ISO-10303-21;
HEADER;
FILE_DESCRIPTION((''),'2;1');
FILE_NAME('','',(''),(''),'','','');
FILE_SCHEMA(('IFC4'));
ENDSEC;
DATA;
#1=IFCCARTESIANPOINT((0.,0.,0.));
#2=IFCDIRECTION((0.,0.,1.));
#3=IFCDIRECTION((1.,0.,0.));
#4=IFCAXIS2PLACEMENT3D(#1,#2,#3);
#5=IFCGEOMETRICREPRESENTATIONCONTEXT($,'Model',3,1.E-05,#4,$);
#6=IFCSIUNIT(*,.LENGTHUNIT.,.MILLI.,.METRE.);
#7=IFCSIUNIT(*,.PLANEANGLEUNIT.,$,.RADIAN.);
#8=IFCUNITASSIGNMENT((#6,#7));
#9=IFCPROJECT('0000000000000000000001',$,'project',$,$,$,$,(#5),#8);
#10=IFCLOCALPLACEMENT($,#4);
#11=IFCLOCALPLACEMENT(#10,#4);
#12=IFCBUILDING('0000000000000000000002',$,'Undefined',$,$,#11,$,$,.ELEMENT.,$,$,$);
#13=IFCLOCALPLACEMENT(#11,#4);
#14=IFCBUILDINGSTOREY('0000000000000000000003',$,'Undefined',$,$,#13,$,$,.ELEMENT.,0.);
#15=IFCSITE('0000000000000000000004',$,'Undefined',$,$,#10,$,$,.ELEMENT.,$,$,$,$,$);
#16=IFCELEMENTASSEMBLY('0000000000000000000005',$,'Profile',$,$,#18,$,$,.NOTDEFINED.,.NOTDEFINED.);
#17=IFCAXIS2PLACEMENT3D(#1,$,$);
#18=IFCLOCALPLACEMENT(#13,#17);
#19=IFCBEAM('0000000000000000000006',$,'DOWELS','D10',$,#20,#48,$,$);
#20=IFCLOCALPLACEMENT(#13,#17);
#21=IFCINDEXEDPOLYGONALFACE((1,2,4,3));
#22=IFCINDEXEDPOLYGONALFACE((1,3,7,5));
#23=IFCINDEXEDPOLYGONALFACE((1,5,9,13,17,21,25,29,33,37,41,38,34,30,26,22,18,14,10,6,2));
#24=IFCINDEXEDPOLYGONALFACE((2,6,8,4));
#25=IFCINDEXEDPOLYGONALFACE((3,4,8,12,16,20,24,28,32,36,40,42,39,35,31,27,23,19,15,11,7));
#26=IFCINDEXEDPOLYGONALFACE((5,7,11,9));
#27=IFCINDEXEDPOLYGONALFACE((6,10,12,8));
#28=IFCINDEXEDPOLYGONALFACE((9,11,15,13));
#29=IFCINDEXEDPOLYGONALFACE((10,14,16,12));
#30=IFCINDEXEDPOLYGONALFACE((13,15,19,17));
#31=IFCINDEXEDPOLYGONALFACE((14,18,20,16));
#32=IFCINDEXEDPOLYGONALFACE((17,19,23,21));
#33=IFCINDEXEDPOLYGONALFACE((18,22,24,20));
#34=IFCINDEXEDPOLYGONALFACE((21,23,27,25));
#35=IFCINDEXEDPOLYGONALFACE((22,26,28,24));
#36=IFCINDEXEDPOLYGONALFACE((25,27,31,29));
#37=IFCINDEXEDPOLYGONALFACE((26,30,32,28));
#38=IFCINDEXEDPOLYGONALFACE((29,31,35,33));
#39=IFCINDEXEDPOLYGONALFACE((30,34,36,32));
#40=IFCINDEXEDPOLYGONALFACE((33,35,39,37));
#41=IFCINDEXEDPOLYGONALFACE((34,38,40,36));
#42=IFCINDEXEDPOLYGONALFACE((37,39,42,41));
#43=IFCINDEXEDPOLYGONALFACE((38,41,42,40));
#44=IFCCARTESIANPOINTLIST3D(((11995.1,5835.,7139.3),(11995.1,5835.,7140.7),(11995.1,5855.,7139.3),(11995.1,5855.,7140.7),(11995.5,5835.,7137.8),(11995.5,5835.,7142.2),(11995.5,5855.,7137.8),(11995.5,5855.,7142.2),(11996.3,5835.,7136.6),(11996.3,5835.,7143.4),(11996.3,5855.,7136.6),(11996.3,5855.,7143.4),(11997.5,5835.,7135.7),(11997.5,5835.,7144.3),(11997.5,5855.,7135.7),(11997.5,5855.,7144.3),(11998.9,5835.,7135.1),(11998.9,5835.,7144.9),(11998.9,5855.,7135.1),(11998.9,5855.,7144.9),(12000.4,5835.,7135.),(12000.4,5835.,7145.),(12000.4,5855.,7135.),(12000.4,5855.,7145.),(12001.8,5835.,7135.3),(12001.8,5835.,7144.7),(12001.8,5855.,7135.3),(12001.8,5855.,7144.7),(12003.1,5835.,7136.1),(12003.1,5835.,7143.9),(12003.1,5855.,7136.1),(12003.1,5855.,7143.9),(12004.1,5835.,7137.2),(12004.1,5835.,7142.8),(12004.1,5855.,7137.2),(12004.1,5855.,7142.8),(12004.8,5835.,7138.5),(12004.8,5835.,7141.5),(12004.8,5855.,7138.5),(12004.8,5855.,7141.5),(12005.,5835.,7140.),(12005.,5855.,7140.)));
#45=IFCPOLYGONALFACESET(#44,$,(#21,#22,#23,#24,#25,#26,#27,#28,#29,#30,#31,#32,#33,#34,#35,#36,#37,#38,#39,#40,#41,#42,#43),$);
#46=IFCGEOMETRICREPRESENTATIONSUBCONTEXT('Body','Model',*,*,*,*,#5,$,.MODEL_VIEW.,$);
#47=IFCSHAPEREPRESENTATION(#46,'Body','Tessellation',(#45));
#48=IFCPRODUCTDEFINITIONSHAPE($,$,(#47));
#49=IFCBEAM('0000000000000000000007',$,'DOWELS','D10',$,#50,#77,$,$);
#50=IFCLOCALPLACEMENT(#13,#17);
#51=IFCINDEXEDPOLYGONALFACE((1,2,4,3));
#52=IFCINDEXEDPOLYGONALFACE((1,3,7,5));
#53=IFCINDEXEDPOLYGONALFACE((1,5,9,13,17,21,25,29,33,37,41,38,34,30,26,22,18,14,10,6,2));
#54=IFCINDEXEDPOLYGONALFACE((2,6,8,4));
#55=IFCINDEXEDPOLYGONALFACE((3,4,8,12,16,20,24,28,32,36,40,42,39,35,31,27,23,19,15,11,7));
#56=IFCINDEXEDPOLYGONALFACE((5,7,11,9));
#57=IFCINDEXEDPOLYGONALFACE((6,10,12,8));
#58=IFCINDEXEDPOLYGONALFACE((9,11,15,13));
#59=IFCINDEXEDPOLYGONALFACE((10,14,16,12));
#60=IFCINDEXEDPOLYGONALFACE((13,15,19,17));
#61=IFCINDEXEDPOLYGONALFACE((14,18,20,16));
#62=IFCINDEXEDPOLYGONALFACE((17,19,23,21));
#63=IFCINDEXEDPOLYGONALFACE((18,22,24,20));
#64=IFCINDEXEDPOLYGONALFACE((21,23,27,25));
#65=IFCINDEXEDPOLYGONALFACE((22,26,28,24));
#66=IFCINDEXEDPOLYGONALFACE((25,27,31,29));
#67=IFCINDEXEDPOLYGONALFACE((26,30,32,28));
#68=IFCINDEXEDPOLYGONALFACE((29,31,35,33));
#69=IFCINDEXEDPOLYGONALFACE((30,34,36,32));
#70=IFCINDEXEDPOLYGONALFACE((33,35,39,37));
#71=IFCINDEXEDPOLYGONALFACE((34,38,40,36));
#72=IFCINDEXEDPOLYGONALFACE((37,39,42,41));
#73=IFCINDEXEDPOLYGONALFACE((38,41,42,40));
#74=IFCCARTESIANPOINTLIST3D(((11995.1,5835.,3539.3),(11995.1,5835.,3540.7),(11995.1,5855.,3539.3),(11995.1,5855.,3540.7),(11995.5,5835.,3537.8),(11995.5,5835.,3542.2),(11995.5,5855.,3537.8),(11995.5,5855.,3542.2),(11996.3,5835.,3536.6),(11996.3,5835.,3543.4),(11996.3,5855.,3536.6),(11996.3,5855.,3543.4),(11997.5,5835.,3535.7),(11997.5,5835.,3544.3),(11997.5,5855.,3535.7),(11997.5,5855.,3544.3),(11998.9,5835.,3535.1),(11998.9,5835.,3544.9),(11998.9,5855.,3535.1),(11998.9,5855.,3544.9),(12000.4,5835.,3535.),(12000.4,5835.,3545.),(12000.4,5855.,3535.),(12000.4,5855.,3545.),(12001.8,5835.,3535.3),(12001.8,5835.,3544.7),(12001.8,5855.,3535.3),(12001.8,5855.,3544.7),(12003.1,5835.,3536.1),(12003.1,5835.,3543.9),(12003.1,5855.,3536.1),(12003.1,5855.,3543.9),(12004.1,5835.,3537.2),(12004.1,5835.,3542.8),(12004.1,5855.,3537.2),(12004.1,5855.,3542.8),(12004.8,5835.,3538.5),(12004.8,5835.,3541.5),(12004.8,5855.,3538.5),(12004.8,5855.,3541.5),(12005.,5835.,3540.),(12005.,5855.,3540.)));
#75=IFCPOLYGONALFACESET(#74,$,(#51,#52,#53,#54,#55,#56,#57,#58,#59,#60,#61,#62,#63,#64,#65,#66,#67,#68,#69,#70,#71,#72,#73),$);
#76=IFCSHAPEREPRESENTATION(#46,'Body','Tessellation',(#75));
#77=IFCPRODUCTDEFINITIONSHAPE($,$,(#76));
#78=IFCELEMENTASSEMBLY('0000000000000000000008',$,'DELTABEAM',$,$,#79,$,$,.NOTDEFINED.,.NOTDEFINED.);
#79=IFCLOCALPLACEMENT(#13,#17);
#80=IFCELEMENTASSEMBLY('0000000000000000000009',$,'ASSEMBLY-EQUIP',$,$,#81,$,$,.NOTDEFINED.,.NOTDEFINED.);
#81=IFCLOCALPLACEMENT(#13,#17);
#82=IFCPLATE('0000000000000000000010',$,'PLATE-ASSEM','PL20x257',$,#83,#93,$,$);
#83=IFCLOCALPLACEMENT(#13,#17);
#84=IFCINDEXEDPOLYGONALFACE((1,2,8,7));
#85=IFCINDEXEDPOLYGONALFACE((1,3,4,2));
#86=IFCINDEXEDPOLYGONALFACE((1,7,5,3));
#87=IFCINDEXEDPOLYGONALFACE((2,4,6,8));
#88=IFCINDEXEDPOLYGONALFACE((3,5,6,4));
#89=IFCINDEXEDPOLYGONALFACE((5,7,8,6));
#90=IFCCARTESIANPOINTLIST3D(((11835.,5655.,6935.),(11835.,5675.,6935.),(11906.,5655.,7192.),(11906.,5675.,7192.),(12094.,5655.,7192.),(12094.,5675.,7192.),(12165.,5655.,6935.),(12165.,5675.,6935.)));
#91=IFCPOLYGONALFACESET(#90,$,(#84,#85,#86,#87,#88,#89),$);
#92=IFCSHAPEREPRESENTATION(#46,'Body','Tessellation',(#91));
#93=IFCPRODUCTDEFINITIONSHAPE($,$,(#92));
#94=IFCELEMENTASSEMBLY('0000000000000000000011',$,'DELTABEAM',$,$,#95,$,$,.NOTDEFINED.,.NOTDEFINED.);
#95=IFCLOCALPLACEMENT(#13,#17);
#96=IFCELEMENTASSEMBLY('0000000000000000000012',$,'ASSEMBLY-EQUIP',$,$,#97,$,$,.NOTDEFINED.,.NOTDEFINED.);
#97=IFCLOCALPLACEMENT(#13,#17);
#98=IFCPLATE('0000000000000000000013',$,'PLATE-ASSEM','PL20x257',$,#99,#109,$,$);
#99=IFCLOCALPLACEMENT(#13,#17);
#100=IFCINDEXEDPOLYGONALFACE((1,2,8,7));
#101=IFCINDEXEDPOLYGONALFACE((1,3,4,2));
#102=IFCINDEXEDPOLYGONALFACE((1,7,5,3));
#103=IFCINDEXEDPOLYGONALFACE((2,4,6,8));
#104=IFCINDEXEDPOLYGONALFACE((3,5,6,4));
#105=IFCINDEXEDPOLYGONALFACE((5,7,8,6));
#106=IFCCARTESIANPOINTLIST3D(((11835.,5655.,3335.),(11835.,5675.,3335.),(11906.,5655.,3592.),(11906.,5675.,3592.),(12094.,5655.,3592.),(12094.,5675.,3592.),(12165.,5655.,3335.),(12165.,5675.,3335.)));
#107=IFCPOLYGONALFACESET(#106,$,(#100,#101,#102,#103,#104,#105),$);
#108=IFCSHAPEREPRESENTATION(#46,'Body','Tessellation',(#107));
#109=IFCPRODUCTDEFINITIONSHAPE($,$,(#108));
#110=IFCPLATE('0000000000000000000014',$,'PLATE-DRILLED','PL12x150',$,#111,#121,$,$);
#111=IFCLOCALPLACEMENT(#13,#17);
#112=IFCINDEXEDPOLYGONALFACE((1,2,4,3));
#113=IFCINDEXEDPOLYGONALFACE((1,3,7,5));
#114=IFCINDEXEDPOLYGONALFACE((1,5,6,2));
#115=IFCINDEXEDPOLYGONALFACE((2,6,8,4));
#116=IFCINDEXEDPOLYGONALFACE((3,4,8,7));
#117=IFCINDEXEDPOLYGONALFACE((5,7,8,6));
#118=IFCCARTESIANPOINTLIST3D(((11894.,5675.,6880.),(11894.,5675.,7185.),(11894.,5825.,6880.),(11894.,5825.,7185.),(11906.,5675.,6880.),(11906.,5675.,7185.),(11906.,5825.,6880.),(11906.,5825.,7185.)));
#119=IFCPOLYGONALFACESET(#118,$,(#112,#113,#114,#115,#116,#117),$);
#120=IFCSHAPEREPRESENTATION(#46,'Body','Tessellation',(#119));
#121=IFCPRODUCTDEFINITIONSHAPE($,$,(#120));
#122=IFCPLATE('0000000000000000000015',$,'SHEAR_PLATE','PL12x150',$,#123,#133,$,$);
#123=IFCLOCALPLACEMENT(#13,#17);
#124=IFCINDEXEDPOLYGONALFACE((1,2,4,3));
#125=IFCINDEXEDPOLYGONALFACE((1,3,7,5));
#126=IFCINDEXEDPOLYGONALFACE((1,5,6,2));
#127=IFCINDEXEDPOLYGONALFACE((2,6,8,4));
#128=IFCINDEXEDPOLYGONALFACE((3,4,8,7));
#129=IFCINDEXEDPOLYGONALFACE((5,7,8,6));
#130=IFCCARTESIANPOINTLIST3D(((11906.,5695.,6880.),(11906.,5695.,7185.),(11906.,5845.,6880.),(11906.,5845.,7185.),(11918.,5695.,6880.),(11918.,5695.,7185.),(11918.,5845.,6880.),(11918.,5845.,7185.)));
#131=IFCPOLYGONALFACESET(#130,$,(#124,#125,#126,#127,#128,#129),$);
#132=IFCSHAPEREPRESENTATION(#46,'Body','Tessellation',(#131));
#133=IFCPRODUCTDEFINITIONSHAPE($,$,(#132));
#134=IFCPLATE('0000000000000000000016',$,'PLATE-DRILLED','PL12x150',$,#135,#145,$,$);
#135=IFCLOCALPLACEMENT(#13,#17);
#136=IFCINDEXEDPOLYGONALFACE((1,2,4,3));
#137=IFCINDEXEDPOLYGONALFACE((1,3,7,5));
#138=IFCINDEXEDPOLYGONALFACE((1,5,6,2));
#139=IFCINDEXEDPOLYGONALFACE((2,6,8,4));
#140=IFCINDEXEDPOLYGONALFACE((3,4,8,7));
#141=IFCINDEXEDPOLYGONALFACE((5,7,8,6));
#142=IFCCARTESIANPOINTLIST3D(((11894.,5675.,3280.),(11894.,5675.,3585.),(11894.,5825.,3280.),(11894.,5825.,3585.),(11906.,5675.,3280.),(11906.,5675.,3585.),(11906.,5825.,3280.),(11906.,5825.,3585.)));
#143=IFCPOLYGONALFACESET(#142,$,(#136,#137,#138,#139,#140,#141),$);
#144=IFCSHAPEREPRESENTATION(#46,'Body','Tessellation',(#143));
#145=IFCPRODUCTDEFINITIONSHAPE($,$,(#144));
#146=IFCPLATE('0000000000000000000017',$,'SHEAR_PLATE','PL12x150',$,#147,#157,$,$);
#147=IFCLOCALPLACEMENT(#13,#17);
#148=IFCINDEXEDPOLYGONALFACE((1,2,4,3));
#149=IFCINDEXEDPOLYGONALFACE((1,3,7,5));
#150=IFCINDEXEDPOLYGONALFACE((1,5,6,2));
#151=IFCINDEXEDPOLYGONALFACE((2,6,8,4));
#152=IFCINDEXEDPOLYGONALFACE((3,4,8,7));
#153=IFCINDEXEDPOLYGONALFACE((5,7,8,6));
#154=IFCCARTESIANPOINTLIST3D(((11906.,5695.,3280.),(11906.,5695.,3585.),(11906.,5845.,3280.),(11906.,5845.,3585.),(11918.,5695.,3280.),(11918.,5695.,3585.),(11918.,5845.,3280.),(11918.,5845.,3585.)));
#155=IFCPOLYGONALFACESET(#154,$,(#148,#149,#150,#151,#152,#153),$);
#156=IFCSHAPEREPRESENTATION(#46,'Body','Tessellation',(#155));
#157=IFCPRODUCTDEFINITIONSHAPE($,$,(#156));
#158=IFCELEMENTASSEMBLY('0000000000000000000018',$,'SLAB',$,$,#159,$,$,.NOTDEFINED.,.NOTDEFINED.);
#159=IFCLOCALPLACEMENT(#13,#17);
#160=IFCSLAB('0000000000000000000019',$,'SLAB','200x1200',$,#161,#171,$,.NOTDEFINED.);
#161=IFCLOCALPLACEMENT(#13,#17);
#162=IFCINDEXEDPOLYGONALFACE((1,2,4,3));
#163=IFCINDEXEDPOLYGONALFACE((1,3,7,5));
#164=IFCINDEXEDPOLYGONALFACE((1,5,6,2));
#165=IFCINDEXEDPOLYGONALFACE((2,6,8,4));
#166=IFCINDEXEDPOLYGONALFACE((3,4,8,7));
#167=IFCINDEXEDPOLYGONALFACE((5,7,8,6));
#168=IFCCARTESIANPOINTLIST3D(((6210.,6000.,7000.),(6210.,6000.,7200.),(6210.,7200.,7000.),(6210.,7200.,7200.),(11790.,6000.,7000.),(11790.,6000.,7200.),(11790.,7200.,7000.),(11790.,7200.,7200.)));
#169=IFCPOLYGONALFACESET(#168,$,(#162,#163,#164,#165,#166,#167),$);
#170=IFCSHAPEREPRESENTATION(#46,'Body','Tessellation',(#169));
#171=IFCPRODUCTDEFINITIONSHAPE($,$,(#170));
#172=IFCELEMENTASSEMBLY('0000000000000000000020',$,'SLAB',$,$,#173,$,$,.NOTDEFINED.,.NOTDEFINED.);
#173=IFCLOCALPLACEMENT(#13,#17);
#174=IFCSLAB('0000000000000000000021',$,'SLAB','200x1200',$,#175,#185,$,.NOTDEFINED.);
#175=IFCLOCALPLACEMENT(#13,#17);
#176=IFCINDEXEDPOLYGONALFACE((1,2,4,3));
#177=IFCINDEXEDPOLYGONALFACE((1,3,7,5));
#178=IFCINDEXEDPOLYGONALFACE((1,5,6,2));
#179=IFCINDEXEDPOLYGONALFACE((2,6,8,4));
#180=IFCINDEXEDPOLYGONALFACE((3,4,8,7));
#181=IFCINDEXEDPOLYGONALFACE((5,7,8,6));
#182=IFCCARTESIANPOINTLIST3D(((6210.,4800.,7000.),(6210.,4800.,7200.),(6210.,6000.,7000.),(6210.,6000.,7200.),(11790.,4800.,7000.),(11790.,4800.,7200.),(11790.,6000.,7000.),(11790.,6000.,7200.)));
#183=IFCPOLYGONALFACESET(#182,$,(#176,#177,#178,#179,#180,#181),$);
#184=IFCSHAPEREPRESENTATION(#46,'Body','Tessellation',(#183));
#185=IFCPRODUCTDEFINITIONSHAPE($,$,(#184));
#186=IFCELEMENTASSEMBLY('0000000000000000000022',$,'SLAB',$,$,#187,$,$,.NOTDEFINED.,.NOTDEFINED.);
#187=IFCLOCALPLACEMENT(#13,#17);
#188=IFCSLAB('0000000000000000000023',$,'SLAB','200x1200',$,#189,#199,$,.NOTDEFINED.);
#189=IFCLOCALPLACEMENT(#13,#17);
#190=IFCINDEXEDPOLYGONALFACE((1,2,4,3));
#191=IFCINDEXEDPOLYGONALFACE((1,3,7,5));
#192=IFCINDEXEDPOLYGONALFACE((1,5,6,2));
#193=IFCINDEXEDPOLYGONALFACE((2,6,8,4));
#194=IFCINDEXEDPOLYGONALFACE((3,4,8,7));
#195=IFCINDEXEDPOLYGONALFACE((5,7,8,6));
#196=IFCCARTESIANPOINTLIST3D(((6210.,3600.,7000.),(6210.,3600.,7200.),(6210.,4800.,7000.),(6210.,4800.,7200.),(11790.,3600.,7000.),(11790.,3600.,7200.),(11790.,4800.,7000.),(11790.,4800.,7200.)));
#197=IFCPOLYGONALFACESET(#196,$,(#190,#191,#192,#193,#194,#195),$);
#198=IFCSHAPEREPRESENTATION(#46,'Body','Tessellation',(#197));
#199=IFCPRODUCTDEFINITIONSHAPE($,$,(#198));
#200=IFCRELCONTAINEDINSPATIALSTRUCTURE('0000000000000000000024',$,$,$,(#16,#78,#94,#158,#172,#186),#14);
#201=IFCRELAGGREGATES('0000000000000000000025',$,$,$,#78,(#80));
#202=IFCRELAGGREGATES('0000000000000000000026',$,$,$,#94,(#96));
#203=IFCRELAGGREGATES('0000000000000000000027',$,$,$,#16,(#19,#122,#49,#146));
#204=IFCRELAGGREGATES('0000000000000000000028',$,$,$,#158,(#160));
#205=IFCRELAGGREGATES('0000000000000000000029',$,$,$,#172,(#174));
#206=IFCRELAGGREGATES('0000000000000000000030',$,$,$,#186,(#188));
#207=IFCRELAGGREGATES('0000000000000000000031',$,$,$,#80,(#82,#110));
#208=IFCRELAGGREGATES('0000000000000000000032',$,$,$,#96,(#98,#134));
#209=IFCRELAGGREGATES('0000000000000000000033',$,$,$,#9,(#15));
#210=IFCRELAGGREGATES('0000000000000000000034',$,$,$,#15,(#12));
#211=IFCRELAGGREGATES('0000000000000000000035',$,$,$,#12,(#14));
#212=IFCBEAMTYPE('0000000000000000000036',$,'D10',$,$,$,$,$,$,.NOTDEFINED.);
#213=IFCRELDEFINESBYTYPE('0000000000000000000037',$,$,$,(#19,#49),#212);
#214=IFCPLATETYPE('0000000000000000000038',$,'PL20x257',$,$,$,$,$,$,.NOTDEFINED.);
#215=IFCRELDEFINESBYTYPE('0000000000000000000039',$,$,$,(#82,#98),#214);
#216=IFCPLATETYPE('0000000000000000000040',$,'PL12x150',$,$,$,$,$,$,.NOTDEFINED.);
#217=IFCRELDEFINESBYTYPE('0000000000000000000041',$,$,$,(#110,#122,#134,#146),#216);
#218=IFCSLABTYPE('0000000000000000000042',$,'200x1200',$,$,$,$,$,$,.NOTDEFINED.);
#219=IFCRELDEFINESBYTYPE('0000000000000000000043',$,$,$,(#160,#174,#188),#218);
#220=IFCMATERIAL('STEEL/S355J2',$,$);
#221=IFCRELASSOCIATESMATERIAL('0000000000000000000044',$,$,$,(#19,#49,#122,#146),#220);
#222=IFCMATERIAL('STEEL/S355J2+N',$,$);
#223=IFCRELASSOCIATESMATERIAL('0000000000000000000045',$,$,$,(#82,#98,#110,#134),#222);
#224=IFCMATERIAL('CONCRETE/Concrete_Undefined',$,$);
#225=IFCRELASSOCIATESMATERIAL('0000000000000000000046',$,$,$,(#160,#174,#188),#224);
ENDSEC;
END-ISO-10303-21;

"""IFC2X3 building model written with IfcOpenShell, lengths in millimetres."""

from ifc_helpers import new_model, si_unit, frame, origin_with_axes, origin_2d_with_axis, place, context, subcontext, project, spatial, polyline, circle, outline, extrude, material, type_object, element, aggregate, save


model = new_model("IFC2X3")

# Units and contexts
model_context = context("Model", 3, precision=1e-05, world=origin_with_axes())
body_context = subcontext(model_context, "Body", "Model", "MODEL_VIEW")
ifc_project = project(units=[si_unit("LENGTHUNIT", "METRE", prefix="MILLI"), si_unit("PLANEANGLEUNIT", "RADIAN")], contexts=[model_context])

# Site, building, storey
site_placement = place(None, origin_with_axes())
site = spatial("IfcSite", under=ifc_project, at=site_placement, Name="Undefined", CompositionType="ELEMENT")
building_placement = place(site_placement, origin_with_axes())
building = spatial("IfcBuilding", under=site, at=building_placement, Name="Undefined", CompositionType="ELEMENT")
storey_placement = place(building_placement, origin_with_axes())
storey = spatial("IfcBuildingStorey", under=building, at=storey_placement, Name="Undefined", CompositionType="ELEMENT", Elevation=0.0)

# Element assembly, beams
assembly_1_placement = place(storey_placement, origin_with_axes())
assembly_1 = element("IfcElementAssembly", 1, at=assembly_1_placement, inside=storey, Name="Profile", AssemblyPlace="NOTDEFINED", PredefinedType="NOTDEFINED")
ifc_material_1 = material(Name="STEEL/S355J2")
beam_type_1 = type_object("IfcBeamType", Name="D10", PredefinedType="NOTDEFINED")
beam_1_placement = place(assembly_1_placement, frame((12000.0, 5835.0, 7140.0), z_axis=(0.0, 0.0, 1.0), x_axis=(0.0, 1.0, 0.0)))
beam_1 = element("IfcBeam", 2, at=beam_1_placement, type_object=beam_type_1, material=ifc_material_1, Name="DOWELS", Description="D10", context=body_context, shape_type="SweptSolid", body=[
    extrude(circle(Radius=5.0, at=origin_2d_with_axis()), frame((20.0, 0.0, 0.0), z_axis=(-1.0, 0.0, 0.0), x_axis=(0.0, -1.0, 0.0)), (0.0, 0.0, 1.0), 20.0),
])
beam_2_placement = place(assembly_1_placement, frame((12000.0, 5835.0, 3540.0), z_axis=(0.0, 0.0, 1.0), x_axis=(0.0, 1.0, 0.0)))
beam_2 = element("IfcBeam", 3, at=beam_2_placement, type_object=beam_type_1, material=ifc_material_1, Name="DOWELS", Description="D10", context=body_context, shape_type="SweptSolid", body=[
    extrude(circle(Radius=5.0, at=origin_2d_with_axis()), frame((20.0, 0.0, 0.0), z_axis=(-1.0, 0.0, 0.0), x_axis=(0.0, -1.0, 0.0)), (0.0, 0.0, 1.0), 20.0),
])

# Element assemblies, plates
assembly_2_placement = place(storey_placement, origin_with_axes())
assembly_2 = element("IfcElementAssembly", 4, at=assembly_2_placement, inside=storey, Name="DELTABEAM", AssemblyPlace="NOTDEFINED", PredefinedType="NOTDEFINED")
assembly_3_placement = place(assembly_2_placement, origin_with_axes())
assembly_3 = element("IfcElementAssembly", 5, at=assembly_3_placement, Name="ASSEMBLY-EQUIP", AssemblyPlace="NOTDEFINED", PredefinedType="NOTDEFINED")
aggregate(assembly_2, [assembly_3])
ifc_material_2 = material(Name="STEEL/S355J2+N")
plate_type_1 = type_object("IfcPlateType", Name="PL20x257", PredefinedType="NOTDEFINED")
plate_1_placement = place(assembly_3_placement, frame((11835.0, 5665.0, 6935.0), z_axis=(0.0, -1.0, 0.0), x_axis=(1.0, 0.0, 0.0)))
plate_1 = element("IfcPlate", 6, at=plate_1_placement, type_object=plate_type_1, material=ifc_material_2, Name="PLATE-ASSEM", Description="PL20x257", context=body_context, shape_type="SweptSolid", body=[
    extrude(outline(polyline([(0.0, 0.0), (330.0, 0.0), (259.0, 257.0), (71.0, 257.0), (0.0, 0.0)])), frame((0.0, 0.0, -10.0), z_axis=(0.0, 0.0, 1.0), x_axis=(1.0, 0.0, 0.0)), (0.0, 0.0, 1.0), 20.0),
])
assembly_4_placement = place(storey_placement, origin_with_axes())
assembly_4 = element("IfcElementAssembly", 7, at=assembly_4_placement, inside=storey, Name="DELTABEAM", AssemblyPlace="NOTDEFINED", PredefinedType="NOTDEFINED")
assembly_5_placement = place(assembly_4_placement, origin_with_axes())
assembly_5 = element("IfcElementAssembly", 8, at=assembly_5_placement, Name="ASSEMBLY-EQUIP", AssemblyPlace="NOTDEFINED", PredefinedType="NOTDEFINED")
aggregate(assembly_4, [assembly_5])
plate_2_placement = place(assembly_5_placement, frame((11835.0, 5665.0, 3335.0), z_axis=(0.0, -1.0, 0.0), x_axis=(1.0, 0.0, 0.0)))
plate_2 = element("IfcPlate", 9, at=plate_2_placement, type_object=plate_type_1, material=ifc_material_2, Name="PLATE-ASSEM", Description="PL20x257", context=body_context, shape_type="SweptSolid", body=[
    extrude(outline(polyline([(0.0, 0.0), (330.0, 0.0), (259.0, 257.0), (71.0, 257.0), (0.0, 0.0)])), frame((0.0, 0.0, -10.0), z_axis=(0.0, 0.0, 1.0), x_axis=(1.0, 0.0, 0.0)), (0.0, 0.0, 1.0), 20.0),
])

# Plates
plate_type_2 = type_object("IfcPlateType", Name="PL12x150", PredefinedType="NOTDEFINED")
plate_3_placement = place(assembly_3_placement, frame((11900.0, 5675.0, 7185.0), z_axis=(-1.0, 0.0, 0.0), x_axis=(0.0, 1.0, 0.0)))
plate_3 = element("IfcPlate", 10, at=plate_3_placement, type_object=plate_type_2, material=ifc_material_2, Name="PLATE-DRILLED", Description="PL12x150", context=body_context, shape_type="SweptSolid", body=[
    extrude(outline(polyline([(0.0, 0.0), (150.0, 0.0), (150.0, 0.0), (150.0, 305.0), (150.0, 305.0), (0.0, 305.0), (0.0, 305.0), (0.0, 0.0)])), frame((0.0, 0.0, -6.0), z_axis=(0.0, 0.0, 1.0), x_axis=(1.0, 0.0, 0.0)), (0.0, 0.0, 1.0), 12.0),
])
plate_4_placement = place(assembly_1_placement, frame((11912.0, 5845.0, 7185.0), z_axis=(1.0, 0.0, 0.0), x_axis=(0.0, -1.0, 0.0)))
plate_4 = element("IfcPlate", 11, at=plate_4_placement, type_object=plate_type_2, material=ifc_material_1, Name="SHEAR_PLATE", Description="PL12x150", context=body_context, shape_type="SweptSolid", body=[
    extrude(outline(polyline([(0.0, 0.0), (150.0, 0.0), (150.0, 0.0), (150.0, 305.0), (150.0, 305.0), (0.0, 305.0), (0.0, 305.0), (0.0, 0.0)])), frame((0.0, 0.0, -6.0), z_axis=(0.0, 0.0, 1.0), x_axis=(1.0, 0.0, 0.0)), (0.0, 0.0, 1.0), 12.0),
])
plate_5_placement = place(assembly_5_placement, frame((11900.0, 5675.0, 3585.0), z_axis=(-1.0, 0.0, 0.0), x_axis=(0.0, 1.0, 0.0)))
plate_5 = element("IfcPlate", 12, at=plate_5_placement, type_object=plate_type_2, material=ifc_material_2, Name="PLATE-DRILLED", Description="PL12x150", context=body_context, shape_type="SweptSolid", body=[
    extrude(outline(polyline([(0.0, 0.0), (150.0, 0.0), (150.0, 0.0), (150.0, 305.0), (150.0, 305.0), (0.0, 305.0), (0.0, 305.0), (0.0, 0.0)])), frame((0.0, 0.0, -6.0), z_axis=(0.0, 0.0, 1.0), x_axis=(1.0, 0.0, 0.0)), (0.0, 0.0, 1.0), 12.0),
])
plate_6_placement = place(assembly_1_placement, frame((11912.0, 5845.0, 3585.0), z_axis=(1.0, 0.0, 0.0), x_axis=(0.0, -1.0, 0.0)))
plate_6 = element("IfcPlate", 13, at=plate_6_placement, type_object=plate_type_2, material=ifc_material_1, Name="SHEAR_PLATE", Description="PL12x150", context=body_context, shape_type="SweptSolid", body=[
    extrude(outline(polyline([(0.0, 0.0), (150.0, 0.0), (150.0, 0.0), (150.0, 305.0), (150.0, 305.0), (0.0, 305.0), (0.0, 305.0), (0.0, 0.0)])), frame((0.0, 0.0, -6.0), z_axis=(0.0, 0.0, 1.0), x_axis=(1.0, 0.0, 0.0)), (0.0, 0.0, 1.0), 12.0),
])
aggregate(assembly_1, [beam_1, plate_4, beam_2, plate_6])

# Element assemblies, slabs
assembly_6_placement = place(storey_placement, origin_with_axes())
assembly_6 = element("IfcElementAssembly", 14, at=assembly_6_placement, inside=storey, Name="SLAB", AssemblyPlace="NOTDEFINED", PredefinedType="NOTDEFINED")
ifc_material_3 = material(Name="CONCRETE/Concrete_Undefined")
slab_type = type_object("IfcSlabType", Name="200x1200", PredefinedType="NOTDEFINED")
slab_1_placement = place(assembly_6_placement, frame((11790.0, 6000.0, 7100.0), z_axis=(0.0, 0.0, 1.0), x_axis=(0.0, 1.0, 0.0)))
slab_1 = element("IfcSlab", 15, at=slab_1_placement, type_object=slab_type, material=ifc_material_3, Name="SLAB", Description="200x1200", PredefinedType="NOTDEFINED", context=body_context, shape_type="SweptSolid", body=[
    extrude(outline(polyline([(0.0, 0.0), (1200.0, 0.0), (1200.0, 5580.0), (0.0, 5580.0), (0.0, 0.0)])), frame((0.0, 0.0, -100.0), z_axis=(0.0, 0.0, 1.0), x_axis=(1.0, 0.0, 0.0)), (0.0, 0.0, 1.0), 200.0),
])
aggregate(assembly_6, [slab_1])
assembly_7_placement = place(storey_placement, origin_with_axes())
assembly_7 = element("IfcElementAssembly", 16, at=assembly_7_placement, inside=storey, Name="SLAB", AssemblyPlace="NOTDEFINED", PredefinedType="NOTDEFINED")
slab_2_placement = place(assembly_7_placement, frame((11790.0, 4800.0, 7100.0), z_axis=(0.0, 0.0, 1.0), x_axis=(0.0, 1.0, 0.0)))
slab_2 = element("IfcSlab", 17, at=slab_2_placement, type_object=slab_type, material=ifc_material_3, Name="SLAB", Description="200x1200", PredefinedType="NOTDEFINED", context=body_context, shape_type="SweptSolid", body=[
    extrude(outline(polyline([(0.0, 0.0), (1200.0, 0.0), (1200.0, 5580.0), (0.0, 5580.0), (0.0, 0.0)])), frame((0.0, 0.0, -100.0), z_axis=(0.0, 0.0, 1.0), x_axis=(1.0, 0.0, 0.0)), (0.0, 0.0, 1.0), 200.0),
])
aggregate(assembly_7, [slab_2])
assembly_8_placement = place(storey_placement, origin_with_axes())
assembly_8 = element("IfcElementAssembly", 18, at=assembly_8_placement, inside=storey, Name="SLAB", AssemblyPlace="NOTDEFINED", PredefinedType="NOTDEFINED")
slab_3_placement = place(assembly_8_placement, frame((11790.0, 3600.0, 7100.0), z_axis=(0.0, 0.0, 1.0), x_axis=(0.0, 1.0, 0.0)))
slab_3 = element("IfcSlab", 19, at=slab_3_placement, type_object=slab_type, material=ifc_material_3, Name="SLAB", Description="200x1200", PredefinedType="NOTDEFINED", context=body_context, shape_type="SweptSolid", body=[
    extrude(outline(polyline([(0.0, 0.0), (1200.0, 0.0), (1200.0, 5580.0), (0.0, 5580.0), (0.0, 0.0)])), frame((0.0, 0.0, -100.0), z_axis=(0.0, 0.0, 1.0), x_axis=(1.0, 0.0, 0.0)), (0.0, 0.0, 1.0), 200.0),
])
aggregate(assembly_8, [slab_3])

aggregate(assembly_3, [plate_1, plate_3])
aggregate(assembly_5, [plate_2, plate_5])

save(model, "model.ifc")
